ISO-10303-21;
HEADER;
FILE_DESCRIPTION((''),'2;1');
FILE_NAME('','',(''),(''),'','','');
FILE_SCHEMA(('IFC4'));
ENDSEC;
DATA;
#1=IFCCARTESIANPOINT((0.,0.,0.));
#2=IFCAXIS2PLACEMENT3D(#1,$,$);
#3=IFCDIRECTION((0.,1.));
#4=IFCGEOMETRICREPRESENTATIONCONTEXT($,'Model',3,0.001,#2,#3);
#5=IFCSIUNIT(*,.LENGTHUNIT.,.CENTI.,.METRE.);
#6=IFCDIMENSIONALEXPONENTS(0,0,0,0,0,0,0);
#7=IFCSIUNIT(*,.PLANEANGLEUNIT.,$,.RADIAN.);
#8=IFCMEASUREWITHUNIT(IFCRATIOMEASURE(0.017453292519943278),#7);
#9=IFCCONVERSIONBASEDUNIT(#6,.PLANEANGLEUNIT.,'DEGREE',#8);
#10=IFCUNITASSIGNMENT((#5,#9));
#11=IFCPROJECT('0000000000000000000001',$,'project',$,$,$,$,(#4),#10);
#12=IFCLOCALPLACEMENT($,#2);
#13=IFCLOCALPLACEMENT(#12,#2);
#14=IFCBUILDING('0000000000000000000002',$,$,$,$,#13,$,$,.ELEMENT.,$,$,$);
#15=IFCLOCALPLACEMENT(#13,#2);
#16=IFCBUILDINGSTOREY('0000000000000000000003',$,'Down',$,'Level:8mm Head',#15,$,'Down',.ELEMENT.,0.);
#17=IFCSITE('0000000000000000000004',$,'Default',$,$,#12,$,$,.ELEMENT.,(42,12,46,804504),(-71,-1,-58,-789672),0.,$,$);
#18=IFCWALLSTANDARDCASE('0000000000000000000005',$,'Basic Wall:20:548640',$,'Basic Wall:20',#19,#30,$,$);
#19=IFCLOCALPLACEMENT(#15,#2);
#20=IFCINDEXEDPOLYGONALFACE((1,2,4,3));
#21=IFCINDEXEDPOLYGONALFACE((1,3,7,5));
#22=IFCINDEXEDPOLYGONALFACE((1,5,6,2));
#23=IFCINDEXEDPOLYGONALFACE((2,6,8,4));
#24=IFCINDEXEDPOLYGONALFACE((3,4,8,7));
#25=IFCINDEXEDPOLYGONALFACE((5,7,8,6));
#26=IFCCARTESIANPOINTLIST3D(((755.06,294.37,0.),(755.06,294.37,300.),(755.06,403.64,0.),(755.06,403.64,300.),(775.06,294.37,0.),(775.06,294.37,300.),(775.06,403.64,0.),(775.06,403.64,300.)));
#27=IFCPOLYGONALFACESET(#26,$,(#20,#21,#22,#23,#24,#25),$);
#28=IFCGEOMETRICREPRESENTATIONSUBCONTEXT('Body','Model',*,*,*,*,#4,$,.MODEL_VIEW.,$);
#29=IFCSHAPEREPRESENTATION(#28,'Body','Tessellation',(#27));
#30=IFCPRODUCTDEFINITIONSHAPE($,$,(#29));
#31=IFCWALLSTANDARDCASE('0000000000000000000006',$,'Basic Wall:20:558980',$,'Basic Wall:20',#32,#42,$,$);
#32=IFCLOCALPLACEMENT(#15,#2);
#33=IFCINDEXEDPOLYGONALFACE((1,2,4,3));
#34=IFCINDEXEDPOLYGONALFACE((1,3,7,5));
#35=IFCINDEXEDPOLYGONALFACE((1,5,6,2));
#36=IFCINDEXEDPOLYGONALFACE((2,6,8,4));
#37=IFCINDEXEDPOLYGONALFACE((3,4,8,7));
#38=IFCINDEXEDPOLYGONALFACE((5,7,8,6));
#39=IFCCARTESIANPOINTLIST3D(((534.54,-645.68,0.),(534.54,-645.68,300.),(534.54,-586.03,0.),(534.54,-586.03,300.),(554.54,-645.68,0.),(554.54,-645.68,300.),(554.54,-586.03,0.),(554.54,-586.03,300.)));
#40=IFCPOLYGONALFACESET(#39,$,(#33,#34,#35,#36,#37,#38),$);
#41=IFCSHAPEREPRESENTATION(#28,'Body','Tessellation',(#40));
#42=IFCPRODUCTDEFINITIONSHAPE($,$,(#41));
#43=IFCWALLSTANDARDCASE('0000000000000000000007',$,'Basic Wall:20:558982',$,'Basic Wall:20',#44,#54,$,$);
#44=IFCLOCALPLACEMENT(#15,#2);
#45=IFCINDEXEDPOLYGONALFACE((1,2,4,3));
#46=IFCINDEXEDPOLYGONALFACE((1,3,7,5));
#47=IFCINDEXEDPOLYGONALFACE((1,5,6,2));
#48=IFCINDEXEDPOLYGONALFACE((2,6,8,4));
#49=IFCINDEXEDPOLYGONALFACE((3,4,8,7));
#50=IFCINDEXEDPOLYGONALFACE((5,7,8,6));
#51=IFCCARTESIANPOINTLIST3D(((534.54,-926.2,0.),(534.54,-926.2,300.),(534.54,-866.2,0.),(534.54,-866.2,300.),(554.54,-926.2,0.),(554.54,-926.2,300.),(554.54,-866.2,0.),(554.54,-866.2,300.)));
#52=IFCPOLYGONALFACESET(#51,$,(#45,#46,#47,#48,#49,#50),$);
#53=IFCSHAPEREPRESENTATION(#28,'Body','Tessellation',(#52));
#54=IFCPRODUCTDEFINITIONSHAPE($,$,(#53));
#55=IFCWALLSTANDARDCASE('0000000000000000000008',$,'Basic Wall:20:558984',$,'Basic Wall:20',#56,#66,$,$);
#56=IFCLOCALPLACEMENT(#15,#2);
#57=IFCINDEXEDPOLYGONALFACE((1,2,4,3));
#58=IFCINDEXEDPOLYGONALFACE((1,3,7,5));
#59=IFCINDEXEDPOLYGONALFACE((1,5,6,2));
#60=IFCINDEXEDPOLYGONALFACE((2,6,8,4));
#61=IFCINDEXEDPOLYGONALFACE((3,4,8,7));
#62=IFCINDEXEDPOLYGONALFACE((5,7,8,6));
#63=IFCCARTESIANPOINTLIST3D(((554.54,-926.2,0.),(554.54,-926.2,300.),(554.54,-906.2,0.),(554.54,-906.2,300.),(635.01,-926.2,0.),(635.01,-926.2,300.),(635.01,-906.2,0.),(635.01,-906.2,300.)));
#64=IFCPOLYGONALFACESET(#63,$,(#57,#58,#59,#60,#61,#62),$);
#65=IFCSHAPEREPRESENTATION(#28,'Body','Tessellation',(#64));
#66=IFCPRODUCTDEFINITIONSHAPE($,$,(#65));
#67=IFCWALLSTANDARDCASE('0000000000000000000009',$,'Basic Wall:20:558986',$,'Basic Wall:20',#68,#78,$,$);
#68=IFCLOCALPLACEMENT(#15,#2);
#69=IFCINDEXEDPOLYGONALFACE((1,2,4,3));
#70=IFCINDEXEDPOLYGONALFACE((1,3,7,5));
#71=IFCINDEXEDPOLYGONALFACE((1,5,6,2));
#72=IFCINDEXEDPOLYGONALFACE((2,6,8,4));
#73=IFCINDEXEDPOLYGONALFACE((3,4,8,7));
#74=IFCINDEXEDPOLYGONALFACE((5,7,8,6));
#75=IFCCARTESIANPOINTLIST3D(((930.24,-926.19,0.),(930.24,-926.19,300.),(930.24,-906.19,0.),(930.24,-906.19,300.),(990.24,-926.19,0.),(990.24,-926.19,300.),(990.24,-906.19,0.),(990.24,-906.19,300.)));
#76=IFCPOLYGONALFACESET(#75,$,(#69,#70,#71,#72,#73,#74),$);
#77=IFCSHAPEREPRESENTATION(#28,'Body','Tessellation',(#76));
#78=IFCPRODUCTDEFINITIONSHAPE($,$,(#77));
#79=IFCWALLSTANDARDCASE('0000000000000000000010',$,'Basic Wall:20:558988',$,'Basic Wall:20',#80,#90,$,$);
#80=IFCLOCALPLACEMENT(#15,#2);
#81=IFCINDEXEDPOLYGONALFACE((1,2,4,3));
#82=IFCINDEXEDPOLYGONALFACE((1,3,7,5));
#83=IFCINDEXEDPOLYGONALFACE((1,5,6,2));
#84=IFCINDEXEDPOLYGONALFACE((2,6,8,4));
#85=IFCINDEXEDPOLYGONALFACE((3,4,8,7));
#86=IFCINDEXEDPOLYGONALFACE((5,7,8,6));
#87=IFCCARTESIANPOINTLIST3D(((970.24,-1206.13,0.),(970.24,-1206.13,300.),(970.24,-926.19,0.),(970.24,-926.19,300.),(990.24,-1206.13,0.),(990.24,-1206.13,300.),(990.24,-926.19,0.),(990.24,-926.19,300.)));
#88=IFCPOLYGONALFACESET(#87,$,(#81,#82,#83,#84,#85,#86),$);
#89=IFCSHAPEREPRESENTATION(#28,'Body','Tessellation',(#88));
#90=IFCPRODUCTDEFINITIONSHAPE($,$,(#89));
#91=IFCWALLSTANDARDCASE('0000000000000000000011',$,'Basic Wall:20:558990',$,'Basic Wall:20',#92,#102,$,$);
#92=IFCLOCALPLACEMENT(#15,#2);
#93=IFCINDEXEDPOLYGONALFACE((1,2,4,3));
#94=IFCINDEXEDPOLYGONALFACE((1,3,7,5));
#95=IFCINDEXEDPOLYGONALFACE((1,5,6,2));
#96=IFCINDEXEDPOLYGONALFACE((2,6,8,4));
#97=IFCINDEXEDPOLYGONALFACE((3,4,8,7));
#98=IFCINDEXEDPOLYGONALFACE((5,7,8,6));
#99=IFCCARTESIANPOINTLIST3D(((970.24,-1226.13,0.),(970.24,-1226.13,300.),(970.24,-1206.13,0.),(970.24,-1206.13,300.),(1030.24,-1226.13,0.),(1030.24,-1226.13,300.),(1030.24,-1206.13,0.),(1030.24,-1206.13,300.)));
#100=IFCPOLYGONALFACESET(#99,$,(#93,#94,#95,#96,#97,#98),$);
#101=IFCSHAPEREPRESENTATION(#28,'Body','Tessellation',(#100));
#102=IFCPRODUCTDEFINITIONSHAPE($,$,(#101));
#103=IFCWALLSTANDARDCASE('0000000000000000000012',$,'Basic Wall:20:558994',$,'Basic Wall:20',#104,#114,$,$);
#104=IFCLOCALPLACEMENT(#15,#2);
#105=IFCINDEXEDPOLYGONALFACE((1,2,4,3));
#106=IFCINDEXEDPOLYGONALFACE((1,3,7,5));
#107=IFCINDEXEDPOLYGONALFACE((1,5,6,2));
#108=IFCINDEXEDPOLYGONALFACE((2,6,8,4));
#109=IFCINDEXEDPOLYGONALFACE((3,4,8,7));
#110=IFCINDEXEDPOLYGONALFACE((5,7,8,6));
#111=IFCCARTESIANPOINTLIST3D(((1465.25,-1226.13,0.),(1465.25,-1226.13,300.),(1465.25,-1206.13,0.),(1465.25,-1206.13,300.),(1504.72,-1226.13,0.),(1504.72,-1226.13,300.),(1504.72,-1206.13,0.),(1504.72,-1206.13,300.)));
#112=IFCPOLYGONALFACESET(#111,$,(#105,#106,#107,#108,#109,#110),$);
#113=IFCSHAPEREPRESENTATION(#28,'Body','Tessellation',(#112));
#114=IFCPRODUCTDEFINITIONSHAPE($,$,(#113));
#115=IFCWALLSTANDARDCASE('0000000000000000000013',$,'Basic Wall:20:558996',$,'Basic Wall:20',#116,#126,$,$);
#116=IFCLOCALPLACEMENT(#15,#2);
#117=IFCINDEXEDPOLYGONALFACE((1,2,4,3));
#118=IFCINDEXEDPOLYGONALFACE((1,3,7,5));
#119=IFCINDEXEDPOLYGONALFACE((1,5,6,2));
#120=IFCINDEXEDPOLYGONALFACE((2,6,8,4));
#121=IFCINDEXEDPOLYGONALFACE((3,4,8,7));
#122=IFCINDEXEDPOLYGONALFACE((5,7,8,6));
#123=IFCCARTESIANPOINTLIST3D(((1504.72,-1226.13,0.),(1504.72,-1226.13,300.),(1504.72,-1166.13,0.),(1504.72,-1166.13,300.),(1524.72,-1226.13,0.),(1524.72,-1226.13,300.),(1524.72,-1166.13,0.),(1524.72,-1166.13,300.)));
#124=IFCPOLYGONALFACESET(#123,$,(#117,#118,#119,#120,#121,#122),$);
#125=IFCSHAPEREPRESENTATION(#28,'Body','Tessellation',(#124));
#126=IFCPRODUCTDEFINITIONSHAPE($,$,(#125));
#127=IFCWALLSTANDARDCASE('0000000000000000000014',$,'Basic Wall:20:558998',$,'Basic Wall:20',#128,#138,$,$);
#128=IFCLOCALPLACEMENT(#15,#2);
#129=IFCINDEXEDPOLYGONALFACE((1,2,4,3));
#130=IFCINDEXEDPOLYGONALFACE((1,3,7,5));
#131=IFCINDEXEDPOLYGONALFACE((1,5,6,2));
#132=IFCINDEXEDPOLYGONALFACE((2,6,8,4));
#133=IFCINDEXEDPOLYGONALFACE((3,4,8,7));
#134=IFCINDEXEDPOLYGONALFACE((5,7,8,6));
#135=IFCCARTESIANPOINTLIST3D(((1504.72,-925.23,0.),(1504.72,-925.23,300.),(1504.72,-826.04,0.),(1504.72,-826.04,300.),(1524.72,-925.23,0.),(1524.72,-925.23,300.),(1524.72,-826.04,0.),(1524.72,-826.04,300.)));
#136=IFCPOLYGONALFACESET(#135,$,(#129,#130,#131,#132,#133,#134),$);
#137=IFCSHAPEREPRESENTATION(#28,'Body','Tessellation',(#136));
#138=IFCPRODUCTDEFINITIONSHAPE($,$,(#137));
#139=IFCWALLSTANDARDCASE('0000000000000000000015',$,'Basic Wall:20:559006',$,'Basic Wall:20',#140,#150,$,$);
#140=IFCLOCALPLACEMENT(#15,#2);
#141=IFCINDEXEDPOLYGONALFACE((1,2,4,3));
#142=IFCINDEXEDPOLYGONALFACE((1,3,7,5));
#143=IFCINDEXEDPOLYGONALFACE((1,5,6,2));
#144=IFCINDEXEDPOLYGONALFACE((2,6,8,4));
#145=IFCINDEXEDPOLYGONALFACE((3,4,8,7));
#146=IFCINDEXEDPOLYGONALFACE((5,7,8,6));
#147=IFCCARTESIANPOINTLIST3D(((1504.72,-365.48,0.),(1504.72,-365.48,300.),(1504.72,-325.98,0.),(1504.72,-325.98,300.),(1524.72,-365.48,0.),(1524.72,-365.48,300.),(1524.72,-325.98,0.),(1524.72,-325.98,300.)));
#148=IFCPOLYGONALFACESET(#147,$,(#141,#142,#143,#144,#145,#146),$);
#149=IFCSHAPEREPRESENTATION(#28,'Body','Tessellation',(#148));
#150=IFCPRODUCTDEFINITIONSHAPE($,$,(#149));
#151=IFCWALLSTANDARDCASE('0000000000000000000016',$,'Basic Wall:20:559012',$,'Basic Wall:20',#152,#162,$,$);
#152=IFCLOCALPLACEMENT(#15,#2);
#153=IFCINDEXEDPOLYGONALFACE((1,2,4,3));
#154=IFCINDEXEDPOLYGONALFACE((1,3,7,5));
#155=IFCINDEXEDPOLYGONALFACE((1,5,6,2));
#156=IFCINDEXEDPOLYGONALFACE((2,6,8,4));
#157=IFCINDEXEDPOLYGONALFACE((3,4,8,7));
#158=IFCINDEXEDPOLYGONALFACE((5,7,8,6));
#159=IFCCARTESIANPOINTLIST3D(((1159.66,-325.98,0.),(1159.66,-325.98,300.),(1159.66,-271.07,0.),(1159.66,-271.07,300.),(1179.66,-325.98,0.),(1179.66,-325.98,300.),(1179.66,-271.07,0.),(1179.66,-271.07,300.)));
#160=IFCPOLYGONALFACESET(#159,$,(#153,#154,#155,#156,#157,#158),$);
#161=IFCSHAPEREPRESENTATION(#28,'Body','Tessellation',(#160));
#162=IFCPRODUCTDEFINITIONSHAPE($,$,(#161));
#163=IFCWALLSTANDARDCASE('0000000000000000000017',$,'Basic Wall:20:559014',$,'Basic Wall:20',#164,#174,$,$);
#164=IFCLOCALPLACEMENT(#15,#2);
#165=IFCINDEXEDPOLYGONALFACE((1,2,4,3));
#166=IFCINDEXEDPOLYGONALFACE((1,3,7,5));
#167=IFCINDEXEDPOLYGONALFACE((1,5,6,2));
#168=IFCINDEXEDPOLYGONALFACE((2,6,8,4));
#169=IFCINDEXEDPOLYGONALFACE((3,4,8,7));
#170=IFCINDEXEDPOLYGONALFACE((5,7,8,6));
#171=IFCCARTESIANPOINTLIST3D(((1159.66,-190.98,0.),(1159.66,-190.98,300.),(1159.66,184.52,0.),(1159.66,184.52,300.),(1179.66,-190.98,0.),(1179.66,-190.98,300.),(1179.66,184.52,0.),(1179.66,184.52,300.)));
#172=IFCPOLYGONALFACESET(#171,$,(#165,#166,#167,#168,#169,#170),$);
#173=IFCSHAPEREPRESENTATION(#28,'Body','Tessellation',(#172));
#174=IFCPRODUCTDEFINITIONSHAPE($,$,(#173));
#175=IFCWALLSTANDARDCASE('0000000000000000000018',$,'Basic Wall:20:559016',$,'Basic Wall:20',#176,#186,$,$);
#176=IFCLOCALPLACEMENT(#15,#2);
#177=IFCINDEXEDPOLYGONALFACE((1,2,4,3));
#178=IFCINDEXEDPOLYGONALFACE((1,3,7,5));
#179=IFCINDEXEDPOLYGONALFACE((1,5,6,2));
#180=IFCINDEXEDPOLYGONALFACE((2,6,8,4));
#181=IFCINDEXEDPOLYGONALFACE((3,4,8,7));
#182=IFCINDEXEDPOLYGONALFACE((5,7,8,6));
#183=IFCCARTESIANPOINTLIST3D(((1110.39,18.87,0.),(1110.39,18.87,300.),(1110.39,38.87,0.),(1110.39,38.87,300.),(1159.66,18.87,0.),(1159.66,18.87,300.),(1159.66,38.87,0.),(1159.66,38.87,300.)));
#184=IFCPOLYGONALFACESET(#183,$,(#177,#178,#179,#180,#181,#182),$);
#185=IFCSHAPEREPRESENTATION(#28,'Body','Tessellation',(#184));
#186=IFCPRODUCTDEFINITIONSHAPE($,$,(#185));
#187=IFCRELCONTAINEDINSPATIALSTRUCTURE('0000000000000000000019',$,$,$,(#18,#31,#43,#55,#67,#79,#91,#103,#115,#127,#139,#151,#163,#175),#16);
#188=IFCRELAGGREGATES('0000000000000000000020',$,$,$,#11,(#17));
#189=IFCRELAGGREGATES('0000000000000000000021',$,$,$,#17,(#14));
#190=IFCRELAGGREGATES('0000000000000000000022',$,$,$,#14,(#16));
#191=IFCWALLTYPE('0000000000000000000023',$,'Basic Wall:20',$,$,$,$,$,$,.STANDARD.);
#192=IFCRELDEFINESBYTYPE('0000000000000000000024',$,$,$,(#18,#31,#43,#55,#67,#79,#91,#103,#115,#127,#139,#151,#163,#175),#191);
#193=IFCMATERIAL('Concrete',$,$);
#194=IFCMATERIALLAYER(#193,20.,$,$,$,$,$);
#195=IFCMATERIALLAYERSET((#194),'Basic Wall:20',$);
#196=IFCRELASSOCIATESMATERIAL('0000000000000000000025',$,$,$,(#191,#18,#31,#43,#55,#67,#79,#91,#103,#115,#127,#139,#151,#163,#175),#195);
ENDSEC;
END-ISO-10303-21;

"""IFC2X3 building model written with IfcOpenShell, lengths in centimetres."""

from ifc_helpers import new_model, entity, si_unit, converted_unit, direction, frame, frame_2d, origin, place, context, subcontext, project, spatial, rectangle, extrude, material, layer, layer_set, layer_usage, type_object, element, save


model = new_model("IFC2X3")

# Units and contexts
model_context = context("Model", 3, precision=0.001, world=origin(), true_north=direction((0.0, 1.0)))
body_context = subcontext(model_context, "Body", "Model", "MODEL_VIEW")
ifc_project = project(units=[si_unit("LENGTHUNIT", "METRE", prefix="CENTI"), converted_unit("PLANEANGLEUNIT", "DEGREE", entity("IfcRatioMeasure", 0.017453292519943278), si_unit("PLANEANGLEUNIT", "RADIAN"), dimensions=[0, 0, 0, 0, 0, 0, 0])], contexts=[model_context])

# Site, building, storey
site_placement = place(None, origin())
site = spatial("IfcSite", under=ifc_project, at=site_placement, Name="Default", CompositionType="ELEMENT", RefLatitude=(42, 12, 46, 804504), RefLongitude=(-71, -1, -58, -789672), RefElevation=0.0)
building_placement = place(site_placement, origin())
building = spatial("IfcBuilding", under=site, at=building_placement, CompositionType="ELEMENT")
storey_placement = place(building_placement, origin())
storey = spatial("IfcBuildingStorey", under=building, at=storey_placement, Name="Down", ObjectType="Level:8mm Head", LongName="Down", CompositionType="ELEMENT", Elevation=0.0)

# Walls
ifc_material = material(Name="Concrete")
ifc_layer_1 = layer(ifc_material, 20.0)
ifc_layer_set_1 = layer_set([ifc_layer_1], Name="Basic Wall:20")
ifc_layer_usage_1 = layer_usage(ifc_layer_set_1, "AXIS2", "NEGATIVE", 10.0)
wall_type_1 = type_object("IfcWallType", Name="Basic Wall:20", PredefinedType="STANDARD", material=ifc_layer_set_1)
wall_1_placement = place(storey_placement, frame((765.06, 294.37, 0.0), z_axis=(0.0, 0.0, 1.0), x_axis=(0.0, 1.0, 0.0)))
element("IfcWallStandardCase", 1, at=wall_1_placement, inside=storey, type_object=wall_type_1, material=ifc_layer_usage_1, Name="Basic Wall:20:548640", ObjectType="Basic Wall:20", context=body_context, shape_type="SweptSolid", body=[
    extrude(rectangle(XDim=109.27, YDim=20.0, at=frame_2d((54.64, 0.0), x_axis=(-1.0, 0.0))), origin(), (0.0, 0.0, 1.0), 300.0),
])
ifc_layer_usage_2 = layer_usage(ifc_layer_set_1, "AXIS2", "NEGATIVE", 10.0)
wall_2_placement = place(storey_placement, frame((544.54, -586.03, 0.0), z_axis=(0.0, 0.0, 1.0), x_axis=(0.0, -1.0, 0.0)))
element("IfcWallStandardCase", 2, at=wall_2_placement, inside=storey, type_object=wall_type_1, material=ifc_layer_usage_2, Name="Basic Wall:20:558980", ObjectType="Basic Wall:20", context=body_context, shape_type="SweptSolid", body=[
    extrude(rectangle(XDim=59.65, YDim=20.0, at=frame_2d((29.83, 0.0), x_axis=(-1.0, 0.0))), origin(), (0.0, 0.0, 1.0), 300.0),
])
ifc_layer_usage_3 = layer_usage(ifc_layer_set_1, "AXIS2", "POSITIVE", -10.0)
wall_3_placement = place(storey_placement, frame((544.54, -866.2, 0.0), z_axis=(0.0, 0.0, 1.0), x_axis=(0.0, -1.0, 0.0)))
element("IfcWallStandardCase", 3, at=wall_3_placement, inside=storey, type_object=wall_type_1, material=ifc_layer_usage_3, Name="Basic Wall:20:558982", ObjectType="Basic Wall:20", context=body_context, shape_type="SweptSolid", body=[
    extrude(rectangle(XDim=60.0, YDim=20.0, at=frame_2d((30.0, 0.0), x_axis=(-1.0, 0.0))), origin(), (0.0, 0.0, 1.0), 300.0),
])
ifc_layer_usage_4 = layer_usage(ifc_layer_set_1, "AXIS2", "POSITIVE", -10.0)
wall_4_placement = place(storey_placement, frame((554.54, -916.2, 0.0)))
element("IfcWallStandardCase", 4, at=wall_4_placement, inside=storey, type_object=wall_type_1, material=ifc_layer_usage_4, Name="Basic Wall:20:558984", ObjectType="Basic Wall:20", context=body_context, shape_type="SweptSolid", body=[
    extrude(rectangle(XDim=80.47, YDim=20.0, at=frame_2d((40.23, 0.0), x_axis=(-1.0, 0.0))), origin(), (0.0, 0.0, 1.0), 300.0),
])
ifc_layer_usage_5 = layer_usage(ifc_layer_set_1, "AXIS2", "NEGATIVE", 10.0)
wall_5_placement = place(storey_placement, frame((930.24, -916.19, 0.0)))
element("IfcWallStandardCase", 5, at=wall_5_placement, inside=storey, type_object=wall_type_1, material=ifc_layer_usage_5, Name="Basic Wall:20:558986", ObjectType="Basic Wall:20", context=body_context, shape_type="SweptSolid", body=[
    extrude(rectangle(XDim=60.0, YDim=20.0, at=frame_2d((30.0, 0.0), x_axis=(-1.0, 0.0))), origin(), (0.0, 0.0, 1.0), 300.0),
])
ifc_layer_usage_6 = layer_usage(ifc_layer_set_1, "AXIS2", "NEGATIVE", 10.0)
wall_6_placement = place(storey_placement, frame((980.24, -926.19, 0.0), z_axis=(0.0, 0.0, 1.0), x_axis=(0.0, -1.0, 0.0)))
element("IfcWallStandardCase", 6, at=wall_6_placement, inside=storey, type_object=wall_type_1, material=ifc_layer_usage_6, Name="Basic Wall:20:558988", ObjectType="Basic Wall:20", context=body_context, shape_type="SweptSolid", body=[
    extrude(rectangle(XDim=279.94, YDim=20.0, at=frame_2d((139.97, 0.0), x_axis=(-1.0, 0.0))), origin(), (0.0, 0.0, 1.0), 300.0),
])
ifc_layer_usage_7 = layer_usage(ifc_layer_set_1, "AXIS2", "POSITIVE", -10.0)
wall_7_placement = place(storey_placement, frame((970.24, -1216.13, 0.0)))
element("IfcWallStandardCase", 7, at=wall_7_placement, inside=storey, type_object=wall_type_1, material=ifc_layer_usage_7, Name="Basic Wall:20:558990", ObjectType="Basic Wall:20", context=body_context, shape_type="SweptSolid", body=[
    extrude(rectangle(XDim=60.0, YDim=20.0, at=frame_2d((30.0, 0.0), x_axis=(-1.0, 0.0))), origin(), (0.0, 0.0, 1.0), 300.0),
])
ifc_layer_usage_8 = layer_usage(ifc_layer_set_1, "AXIS2", "NEGATIVE", 10.0)
wall_8_placement = place(storey_placement, frame((1465.25, -1216.13, 0.0)))
element("IfcWallStandardCase", 8, at=wall_8_placement, inside=storey, type_object=wall_type_1, material=ifc_layer_usage_8, Name="Basic Wall:20:558994", ObjectType="Basic Wall:20", context=body_context, shape_type="SweptSolid", body=[
    extrude(rectangle(XDim=39.47, YDim=20.0, at=frame_2d((19.73, 0.0), x_axis=(-1.0, 0.0))), origin(), (0.0, 0.0, 1.0), 300.0),
])
ifc_layer_usage_9 = layer_usage(ifc_layer_set_1, "AXIS2", "POSITIVE", -10.0)
wall_9_placement = place(storey_placement, frame((1514.72, -1226.13, 0.0), z_axis=(0.0, 0.0, 1.0), x_axis=(0.0, 1.0, 0.0)))
element("IfcWallStandardCase", 9, at=wall_9_placement, inside=storey, type_object=wall_type_1, material=ifc_layer_usage_9, Name="Basic Wall:20:558996", ObjectType="Basic Wall:20", context=body_context, shape_type="SweptSolid", body=[
    extrude(rectangle(XDim=60.0, YDim=20.0, at=frame_2d((30.0, 0.0), x_axis=(-1.0, 0.0))), origin(), (0.0, 0.0, 1.0), 300.0),
])
ifc_layer_usage_10 = layer_usage(ifc_layer_set_1, "AXIS2", "POSITIVE", -10.0)
wall_10_placement = place(storey_placement, frame((1514.72, -925.23, 0.0), z_axis=(0.0, 0.0, 1.0), x_axis=(0.0, 1.0, 0.0)))
element("IfcWallStandardCase", 10, at=wall_10_placement, inside=storey, type_object=wall_type_1, material=ifc_layer_usage_10, Name="Basic Wall:20:558998", ObjectType="Basic Wall:20", context=body_context, shape_type="SweptSolid", body=[
    extrude(rectangle(XDim=99.19, YDim=20.0, at=frame_2d((49.59, 0.0), x_axis=(-1.0, 0.0))), origin(), (0.0, 0.0, 1.0), 300.0),
])
ifc_layer_usage_11 = layer_usage(ifc_layer_set_1, "AXIS2", "POSITIVE", -10.0)
wall_11_placement = place(storey_placement, frame((1514.72, -365.48, 0.0), z_axis=(0.0, 0.0, 1.0), x_axis=(0.0, 1.0, 0.0)))
element("IfcWallStandardCase", 11, at=wall_11_placement, inside=storey, type_object=wall_type_1, material=ifc_layer_usage_11, Name="Basic Wall:20:559006", ObjectType="Basic Wall:20", context=body_context, shape_type="SweptSolid", body=[
    extrude(rectangle(XDim=39.5, YDim=20.0, at=frame_2d((19.75, 0.0), x_axis=(-1.0, 0.0))), origin(), (0.0, 0.0, 1.0), 300.0),
])
ifc_layer_usage_12 = layer_usage(ifc_layer_set_1, "AXIS2", "NEGATIVE", 10.0)
wall_12_placement = place(storey_placement, frame((1169.66, -325.98, 0.0), z_axis=(0.0, 0.0, 1.0), x_axis=(0.0, 1.0, 0.0)))
element("IfcWallStandardCase", 12, at=wall_12_placement, inside=storey, type_object=wall_type_1, material=ifc_layer_usage_12, Name="Basic Wall:20:559012", ObjectType="Basic Wall:20", context=body_context, shape_type="SweptSolid", body=[
    extrude(rectangle(XDim=54.91, YDim=20.0, at=frame_2d((27.46, 0.0), x_axis=(-1.0, 0.0))), origin(), (0.0, 0.0, 1.0), 300.0),
])
ifc_layer_usage_13 = layer_usage(ifc_layer_set_1, "AXIS2", "NEGATIVE", 10.0)
wall_13_placement = place(storey_placement, frame((1169.66, -190.98, 0.0), z_axis=(0.0, 0.0, 1.0), x_axis=(0.0, 1.0, 0.0)))
element("IfcWallStandardCase", 13, at=wall_13_placement, inside=storey, type_object=wall_type_1, material=ifc_layer_usage_13, Name="Basic Wall:20:559014", ObjectType="Basic Wall:20", context=body_context, shape_type="SweptSolid", body=[
    extrude(rectangle(XDim=375.5, YDim=20.0, at=frame_2d((187.75, 0.0), x_axis=(-1.0, 0.0))), origin(), (0.0, 0.0, 1.0), 300.0),
])
ifc_layer_usage_14 = layer_usage(ifc_layer_set_1, "AXIS2", "NEGATIVE", 10.0)
wall_14_placement = place(storey_placement, frame((1110.39, 28.87, 0.0)))
element("IfcWallStandardCase", 14, at=wall_14_placement, inside=storey, type_object=wall_type_1, material=ifc_layer_usage_14, Name="Basic Wall:20:559016", ObjectType="Basic Wall:20", context=body_context, shape_type="SweptSolid", body=[
    extrude(rectangle(XDim=49.27, YDim=20.0, at=frame_2d((24.63, 0.0), x_axis=(-1.0, 0.0))), origin(), (0.0, 0.0, 1.0), 300.0),
])

save(model, "model.ifc")
